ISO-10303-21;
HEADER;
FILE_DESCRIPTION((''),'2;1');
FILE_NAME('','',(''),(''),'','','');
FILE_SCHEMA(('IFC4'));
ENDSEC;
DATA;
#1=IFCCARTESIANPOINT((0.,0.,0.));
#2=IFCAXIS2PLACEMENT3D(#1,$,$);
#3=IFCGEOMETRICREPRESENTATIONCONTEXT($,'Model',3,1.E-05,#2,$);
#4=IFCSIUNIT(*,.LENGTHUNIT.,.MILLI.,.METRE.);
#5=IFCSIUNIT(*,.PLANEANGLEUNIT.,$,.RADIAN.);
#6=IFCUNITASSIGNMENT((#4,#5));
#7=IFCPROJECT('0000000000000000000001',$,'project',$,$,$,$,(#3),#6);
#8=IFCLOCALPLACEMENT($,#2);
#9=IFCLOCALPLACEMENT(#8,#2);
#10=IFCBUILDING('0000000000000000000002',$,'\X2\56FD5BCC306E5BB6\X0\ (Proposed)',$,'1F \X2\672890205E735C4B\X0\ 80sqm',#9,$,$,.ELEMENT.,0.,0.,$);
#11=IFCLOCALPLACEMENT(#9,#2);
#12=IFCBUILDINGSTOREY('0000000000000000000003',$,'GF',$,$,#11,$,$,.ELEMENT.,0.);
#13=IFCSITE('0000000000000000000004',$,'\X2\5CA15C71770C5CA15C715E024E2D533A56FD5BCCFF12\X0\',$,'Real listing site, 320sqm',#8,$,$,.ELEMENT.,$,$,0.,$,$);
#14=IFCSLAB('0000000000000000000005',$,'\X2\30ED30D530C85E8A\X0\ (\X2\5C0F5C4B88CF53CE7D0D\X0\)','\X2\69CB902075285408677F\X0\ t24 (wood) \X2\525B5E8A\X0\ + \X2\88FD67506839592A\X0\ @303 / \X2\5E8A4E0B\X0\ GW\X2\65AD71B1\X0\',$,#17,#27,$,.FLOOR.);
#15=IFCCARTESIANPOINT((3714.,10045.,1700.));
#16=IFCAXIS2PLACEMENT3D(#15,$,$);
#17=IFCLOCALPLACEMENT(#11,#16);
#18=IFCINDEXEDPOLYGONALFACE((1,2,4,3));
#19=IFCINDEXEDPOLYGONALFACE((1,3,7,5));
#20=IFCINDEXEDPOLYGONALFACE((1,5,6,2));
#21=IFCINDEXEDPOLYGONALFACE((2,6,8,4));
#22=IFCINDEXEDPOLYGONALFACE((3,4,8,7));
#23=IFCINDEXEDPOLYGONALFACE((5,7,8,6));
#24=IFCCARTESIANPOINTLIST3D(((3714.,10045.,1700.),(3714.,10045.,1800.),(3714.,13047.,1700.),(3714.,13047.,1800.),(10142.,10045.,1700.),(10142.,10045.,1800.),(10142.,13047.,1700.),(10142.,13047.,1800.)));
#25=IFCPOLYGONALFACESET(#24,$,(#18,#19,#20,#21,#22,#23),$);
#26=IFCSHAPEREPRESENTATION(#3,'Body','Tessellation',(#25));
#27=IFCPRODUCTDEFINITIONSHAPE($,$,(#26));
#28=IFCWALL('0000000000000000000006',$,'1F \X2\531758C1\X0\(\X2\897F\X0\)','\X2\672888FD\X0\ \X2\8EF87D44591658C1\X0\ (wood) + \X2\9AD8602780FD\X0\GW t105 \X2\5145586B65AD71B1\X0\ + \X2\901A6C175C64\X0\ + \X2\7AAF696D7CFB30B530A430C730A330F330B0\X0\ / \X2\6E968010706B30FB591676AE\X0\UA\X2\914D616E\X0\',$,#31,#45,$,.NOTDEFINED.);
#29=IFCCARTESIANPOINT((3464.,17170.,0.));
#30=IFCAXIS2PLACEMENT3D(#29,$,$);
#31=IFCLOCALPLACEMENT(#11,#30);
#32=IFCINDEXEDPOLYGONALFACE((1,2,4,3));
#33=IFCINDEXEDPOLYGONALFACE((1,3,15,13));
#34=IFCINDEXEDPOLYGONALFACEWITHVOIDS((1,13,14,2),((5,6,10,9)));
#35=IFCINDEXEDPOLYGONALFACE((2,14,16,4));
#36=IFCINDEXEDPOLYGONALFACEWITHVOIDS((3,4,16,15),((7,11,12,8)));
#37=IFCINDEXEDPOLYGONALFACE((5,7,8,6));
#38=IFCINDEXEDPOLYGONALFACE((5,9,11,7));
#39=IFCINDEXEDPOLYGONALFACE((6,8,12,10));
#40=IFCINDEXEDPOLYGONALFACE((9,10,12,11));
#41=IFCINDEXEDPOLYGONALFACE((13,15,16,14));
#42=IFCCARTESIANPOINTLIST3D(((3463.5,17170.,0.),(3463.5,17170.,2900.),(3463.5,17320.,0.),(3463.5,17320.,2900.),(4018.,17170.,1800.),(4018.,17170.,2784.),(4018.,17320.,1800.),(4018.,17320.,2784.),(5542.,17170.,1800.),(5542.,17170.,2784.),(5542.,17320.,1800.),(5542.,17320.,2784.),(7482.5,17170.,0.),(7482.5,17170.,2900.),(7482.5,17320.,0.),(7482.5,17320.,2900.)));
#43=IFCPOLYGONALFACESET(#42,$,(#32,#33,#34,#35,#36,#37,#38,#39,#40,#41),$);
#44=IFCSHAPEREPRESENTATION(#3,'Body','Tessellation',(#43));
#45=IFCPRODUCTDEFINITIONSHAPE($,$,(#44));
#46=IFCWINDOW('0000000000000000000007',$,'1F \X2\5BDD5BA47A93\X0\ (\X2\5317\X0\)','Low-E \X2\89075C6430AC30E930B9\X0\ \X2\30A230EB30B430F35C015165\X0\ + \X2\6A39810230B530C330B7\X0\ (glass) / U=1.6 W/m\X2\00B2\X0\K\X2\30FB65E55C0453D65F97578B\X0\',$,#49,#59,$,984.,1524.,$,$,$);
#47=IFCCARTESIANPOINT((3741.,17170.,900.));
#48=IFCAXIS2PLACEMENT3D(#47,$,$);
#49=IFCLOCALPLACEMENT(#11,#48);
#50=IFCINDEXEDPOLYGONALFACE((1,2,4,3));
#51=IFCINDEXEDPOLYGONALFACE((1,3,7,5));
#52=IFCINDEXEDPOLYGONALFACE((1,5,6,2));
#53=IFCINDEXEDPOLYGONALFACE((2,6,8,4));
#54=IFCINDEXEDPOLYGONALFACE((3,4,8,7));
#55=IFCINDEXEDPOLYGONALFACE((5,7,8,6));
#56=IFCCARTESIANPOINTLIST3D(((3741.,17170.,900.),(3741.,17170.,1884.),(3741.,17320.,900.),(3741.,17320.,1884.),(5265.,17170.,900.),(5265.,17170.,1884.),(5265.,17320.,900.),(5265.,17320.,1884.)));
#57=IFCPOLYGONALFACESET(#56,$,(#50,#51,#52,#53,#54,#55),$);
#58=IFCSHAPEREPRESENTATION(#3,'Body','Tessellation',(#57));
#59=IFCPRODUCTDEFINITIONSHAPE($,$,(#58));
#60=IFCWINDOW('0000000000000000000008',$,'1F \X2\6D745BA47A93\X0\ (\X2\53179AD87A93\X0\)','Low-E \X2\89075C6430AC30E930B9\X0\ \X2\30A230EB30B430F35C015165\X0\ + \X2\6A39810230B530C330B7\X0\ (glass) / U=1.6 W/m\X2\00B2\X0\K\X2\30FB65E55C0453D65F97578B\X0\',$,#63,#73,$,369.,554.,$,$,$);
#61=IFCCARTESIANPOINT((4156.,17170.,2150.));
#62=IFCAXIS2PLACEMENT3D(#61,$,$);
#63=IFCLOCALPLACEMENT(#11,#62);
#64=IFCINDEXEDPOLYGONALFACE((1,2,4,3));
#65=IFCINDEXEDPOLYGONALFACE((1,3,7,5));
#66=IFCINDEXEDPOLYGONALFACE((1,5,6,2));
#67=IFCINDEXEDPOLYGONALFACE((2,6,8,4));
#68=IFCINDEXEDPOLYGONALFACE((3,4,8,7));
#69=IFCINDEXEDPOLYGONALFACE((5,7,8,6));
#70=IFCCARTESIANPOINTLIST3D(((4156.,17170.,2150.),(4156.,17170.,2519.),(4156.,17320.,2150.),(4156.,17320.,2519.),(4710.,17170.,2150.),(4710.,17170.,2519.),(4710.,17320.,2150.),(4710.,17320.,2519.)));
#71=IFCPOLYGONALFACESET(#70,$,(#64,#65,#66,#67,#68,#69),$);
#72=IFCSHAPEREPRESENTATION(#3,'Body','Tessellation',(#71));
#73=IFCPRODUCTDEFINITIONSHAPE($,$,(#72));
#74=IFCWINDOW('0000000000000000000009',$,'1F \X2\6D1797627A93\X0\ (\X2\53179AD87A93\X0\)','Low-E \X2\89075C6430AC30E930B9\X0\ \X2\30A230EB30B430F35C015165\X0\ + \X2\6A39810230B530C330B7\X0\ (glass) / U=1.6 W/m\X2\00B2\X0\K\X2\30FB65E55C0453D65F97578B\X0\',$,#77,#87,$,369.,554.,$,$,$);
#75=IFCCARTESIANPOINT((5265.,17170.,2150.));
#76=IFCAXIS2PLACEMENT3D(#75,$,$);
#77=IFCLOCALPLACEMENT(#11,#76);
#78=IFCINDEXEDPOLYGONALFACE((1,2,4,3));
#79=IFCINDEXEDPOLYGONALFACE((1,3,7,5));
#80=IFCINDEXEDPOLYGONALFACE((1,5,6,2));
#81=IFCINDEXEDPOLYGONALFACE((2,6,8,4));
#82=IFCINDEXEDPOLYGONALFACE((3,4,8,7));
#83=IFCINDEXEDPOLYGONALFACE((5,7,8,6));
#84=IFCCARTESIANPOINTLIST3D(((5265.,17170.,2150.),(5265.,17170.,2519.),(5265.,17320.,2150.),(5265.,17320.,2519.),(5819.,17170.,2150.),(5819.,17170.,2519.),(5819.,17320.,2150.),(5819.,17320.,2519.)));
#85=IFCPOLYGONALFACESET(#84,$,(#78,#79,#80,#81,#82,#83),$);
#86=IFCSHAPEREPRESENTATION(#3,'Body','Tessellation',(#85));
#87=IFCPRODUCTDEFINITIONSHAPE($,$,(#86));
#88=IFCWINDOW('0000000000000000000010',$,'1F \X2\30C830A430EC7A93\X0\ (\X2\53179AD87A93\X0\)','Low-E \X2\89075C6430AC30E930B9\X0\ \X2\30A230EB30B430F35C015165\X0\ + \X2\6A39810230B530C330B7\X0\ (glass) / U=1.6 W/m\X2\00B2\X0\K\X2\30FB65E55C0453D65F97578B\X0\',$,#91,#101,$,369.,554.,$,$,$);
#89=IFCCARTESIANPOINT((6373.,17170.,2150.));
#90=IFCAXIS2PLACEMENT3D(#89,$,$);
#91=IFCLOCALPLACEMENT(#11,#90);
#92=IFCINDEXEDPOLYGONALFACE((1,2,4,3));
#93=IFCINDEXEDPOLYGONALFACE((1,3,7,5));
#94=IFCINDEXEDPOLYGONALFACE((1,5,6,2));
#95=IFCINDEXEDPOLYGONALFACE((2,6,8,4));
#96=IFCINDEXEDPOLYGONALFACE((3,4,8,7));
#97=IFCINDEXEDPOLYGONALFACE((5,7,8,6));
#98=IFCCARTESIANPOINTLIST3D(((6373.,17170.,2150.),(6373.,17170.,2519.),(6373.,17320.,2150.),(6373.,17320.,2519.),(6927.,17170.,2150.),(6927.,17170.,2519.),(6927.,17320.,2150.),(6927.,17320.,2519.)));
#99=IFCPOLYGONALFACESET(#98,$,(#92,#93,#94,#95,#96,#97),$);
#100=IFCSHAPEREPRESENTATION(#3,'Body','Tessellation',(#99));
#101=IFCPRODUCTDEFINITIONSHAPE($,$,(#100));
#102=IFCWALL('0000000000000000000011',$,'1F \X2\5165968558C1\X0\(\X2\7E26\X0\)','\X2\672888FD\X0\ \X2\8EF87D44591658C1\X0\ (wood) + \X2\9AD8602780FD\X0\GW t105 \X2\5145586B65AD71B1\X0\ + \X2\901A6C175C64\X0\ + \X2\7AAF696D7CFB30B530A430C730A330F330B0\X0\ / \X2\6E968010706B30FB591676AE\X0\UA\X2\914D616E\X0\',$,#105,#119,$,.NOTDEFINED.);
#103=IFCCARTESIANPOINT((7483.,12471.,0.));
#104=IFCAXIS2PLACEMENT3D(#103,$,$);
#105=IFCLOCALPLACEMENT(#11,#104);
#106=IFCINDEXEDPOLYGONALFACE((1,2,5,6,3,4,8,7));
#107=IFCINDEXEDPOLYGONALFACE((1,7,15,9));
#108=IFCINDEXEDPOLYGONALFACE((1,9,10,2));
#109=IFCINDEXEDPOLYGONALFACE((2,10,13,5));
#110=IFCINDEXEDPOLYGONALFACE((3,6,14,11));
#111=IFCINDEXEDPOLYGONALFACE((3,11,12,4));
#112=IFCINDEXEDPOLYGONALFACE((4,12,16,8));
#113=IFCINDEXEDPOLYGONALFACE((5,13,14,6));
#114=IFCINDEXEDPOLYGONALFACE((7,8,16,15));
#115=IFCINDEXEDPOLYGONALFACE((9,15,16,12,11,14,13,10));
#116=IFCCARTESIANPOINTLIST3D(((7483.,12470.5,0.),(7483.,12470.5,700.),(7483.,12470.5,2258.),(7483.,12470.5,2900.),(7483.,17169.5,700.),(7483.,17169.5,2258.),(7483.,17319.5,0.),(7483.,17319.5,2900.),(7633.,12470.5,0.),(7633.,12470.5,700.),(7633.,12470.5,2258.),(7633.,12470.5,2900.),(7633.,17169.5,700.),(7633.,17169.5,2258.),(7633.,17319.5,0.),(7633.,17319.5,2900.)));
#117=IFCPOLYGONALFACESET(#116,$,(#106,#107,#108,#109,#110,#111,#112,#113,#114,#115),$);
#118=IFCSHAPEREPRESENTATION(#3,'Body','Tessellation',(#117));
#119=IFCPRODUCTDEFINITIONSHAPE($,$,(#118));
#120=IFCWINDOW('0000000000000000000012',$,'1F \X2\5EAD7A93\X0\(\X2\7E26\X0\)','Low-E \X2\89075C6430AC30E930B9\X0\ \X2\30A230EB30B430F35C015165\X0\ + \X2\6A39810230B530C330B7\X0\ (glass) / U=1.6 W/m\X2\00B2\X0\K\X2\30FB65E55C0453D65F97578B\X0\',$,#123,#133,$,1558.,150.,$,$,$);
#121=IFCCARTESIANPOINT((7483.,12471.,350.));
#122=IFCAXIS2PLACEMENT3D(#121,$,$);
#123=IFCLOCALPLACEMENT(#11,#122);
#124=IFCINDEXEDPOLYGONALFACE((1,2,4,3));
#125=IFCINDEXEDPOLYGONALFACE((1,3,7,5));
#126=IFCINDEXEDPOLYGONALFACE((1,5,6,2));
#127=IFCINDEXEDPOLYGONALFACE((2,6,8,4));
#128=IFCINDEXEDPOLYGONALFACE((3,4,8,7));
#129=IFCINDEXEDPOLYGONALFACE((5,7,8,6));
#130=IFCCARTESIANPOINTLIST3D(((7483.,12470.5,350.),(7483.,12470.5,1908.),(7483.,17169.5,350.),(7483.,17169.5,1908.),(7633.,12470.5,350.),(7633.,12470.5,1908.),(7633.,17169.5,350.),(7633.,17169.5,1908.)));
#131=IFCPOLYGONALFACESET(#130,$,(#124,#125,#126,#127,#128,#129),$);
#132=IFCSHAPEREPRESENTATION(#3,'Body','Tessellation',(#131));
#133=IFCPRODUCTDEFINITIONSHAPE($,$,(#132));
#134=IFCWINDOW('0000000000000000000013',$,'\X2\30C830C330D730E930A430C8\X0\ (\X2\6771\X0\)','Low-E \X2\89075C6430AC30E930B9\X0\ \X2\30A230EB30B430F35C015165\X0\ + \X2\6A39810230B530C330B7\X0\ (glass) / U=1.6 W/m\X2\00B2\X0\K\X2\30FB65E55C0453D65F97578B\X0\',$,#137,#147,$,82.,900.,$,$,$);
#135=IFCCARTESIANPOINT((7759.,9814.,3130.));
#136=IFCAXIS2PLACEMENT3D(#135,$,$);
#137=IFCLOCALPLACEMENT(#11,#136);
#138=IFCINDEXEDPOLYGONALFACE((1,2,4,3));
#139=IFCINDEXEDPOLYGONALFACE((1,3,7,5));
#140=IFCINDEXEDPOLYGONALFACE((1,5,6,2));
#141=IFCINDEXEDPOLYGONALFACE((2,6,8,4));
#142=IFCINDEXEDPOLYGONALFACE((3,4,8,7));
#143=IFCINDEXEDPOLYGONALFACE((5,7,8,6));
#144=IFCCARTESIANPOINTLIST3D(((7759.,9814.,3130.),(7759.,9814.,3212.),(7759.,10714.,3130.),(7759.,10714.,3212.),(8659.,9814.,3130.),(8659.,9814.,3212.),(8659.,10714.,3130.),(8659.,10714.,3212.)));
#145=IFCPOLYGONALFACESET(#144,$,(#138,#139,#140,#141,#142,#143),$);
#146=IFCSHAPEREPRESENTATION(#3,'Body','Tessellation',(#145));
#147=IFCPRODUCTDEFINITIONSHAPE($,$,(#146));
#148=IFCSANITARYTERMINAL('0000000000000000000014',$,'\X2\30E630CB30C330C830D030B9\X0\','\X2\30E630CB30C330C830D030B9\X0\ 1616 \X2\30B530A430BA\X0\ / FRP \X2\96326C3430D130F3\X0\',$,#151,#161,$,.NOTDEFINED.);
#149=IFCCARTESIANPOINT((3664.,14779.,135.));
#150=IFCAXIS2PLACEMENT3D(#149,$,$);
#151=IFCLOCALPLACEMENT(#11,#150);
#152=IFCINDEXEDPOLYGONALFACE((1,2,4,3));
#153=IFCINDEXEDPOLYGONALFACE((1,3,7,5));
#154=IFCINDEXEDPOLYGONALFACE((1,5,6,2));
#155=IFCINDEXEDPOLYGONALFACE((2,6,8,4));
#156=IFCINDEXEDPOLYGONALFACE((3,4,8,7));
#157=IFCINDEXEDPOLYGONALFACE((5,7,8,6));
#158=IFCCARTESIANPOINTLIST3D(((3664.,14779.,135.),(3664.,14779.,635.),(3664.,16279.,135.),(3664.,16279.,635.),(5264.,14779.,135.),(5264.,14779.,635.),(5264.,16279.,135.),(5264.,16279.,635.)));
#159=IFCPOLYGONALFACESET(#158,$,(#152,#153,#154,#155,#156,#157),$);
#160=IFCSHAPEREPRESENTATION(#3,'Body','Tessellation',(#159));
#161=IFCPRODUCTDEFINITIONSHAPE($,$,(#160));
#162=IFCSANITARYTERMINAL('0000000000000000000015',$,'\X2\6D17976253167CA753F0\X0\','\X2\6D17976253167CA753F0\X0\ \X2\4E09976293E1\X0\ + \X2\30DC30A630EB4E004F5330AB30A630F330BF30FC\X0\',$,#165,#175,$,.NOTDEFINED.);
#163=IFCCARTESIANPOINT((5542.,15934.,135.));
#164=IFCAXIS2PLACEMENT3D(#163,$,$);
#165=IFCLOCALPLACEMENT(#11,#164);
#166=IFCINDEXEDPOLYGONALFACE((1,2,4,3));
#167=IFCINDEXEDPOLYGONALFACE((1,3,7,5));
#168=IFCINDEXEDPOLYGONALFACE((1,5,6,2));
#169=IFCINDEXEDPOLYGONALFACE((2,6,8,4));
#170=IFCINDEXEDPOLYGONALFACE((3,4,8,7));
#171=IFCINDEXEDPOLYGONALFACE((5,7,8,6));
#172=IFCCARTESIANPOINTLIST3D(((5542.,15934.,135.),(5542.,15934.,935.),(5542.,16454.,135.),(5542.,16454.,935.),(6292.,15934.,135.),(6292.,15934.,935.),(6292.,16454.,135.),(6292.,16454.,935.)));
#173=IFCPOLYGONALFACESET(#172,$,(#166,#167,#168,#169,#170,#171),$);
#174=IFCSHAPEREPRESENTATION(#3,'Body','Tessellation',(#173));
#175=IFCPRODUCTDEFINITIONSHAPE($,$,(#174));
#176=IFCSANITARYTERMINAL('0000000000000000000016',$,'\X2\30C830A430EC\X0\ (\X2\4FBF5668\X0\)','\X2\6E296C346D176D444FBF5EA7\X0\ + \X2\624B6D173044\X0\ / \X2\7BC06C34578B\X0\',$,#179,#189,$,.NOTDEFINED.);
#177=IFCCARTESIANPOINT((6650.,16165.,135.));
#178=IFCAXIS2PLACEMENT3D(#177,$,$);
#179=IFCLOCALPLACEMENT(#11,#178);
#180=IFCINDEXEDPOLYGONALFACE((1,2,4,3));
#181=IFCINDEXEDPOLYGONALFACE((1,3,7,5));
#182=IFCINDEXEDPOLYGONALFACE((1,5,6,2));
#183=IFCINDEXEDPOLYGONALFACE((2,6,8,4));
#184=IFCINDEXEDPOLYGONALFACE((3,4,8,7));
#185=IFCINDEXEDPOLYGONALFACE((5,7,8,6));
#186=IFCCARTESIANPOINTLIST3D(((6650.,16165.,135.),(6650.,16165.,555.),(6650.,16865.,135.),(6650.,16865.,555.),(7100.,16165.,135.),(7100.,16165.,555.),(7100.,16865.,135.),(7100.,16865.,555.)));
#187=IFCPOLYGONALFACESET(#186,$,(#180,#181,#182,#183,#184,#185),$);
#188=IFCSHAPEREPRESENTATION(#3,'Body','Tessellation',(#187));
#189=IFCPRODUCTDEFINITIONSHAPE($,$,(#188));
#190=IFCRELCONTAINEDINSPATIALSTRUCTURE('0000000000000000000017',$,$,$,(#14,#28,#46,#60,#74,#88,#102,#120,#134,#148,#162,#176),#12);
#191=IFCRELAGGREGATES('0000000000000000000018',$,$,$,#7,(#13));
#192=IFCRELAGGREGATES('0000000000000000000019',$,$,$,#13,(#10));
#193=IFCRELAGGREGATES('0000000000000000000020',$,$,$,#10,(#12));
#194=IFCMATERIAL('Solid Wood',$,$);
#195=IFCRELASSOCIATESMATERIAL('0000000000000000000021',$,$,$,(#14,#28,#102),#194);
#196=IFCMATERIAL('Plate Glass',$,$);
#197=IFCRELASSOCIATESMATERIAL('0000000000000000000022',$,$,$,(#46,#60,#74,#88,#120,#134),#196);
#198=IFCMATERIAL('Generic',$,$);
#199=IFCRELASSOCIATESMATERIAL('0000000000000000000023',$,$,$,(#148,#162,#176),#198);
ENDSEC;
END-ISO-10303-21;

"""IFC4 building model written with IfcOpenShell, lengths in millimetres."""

from ifc_helpers import new_model, si_unit, frame, frame_2d, origin, place, context, project, spatial, rectangle, extrude, material, element, fill, save


model = new_model("IFC4")

# Units and contexts
model_context = context("Model", 3, precision=1e-05, world=origin())
ifc_project = project(units=[si_unit("LENGTHUNIT", "METRE", prefix="MILLI"), si_unit("PLANEANGLEUNIT", "RADIAN")], contexts=[model_context])

# Site, building, storey
site_placement = place(None, origin())
site = spatial("IfcSite", under=ifc_project, at=site_placement, Name="岡山県岡山市中区国富２", ObjectType="Real listing site, 320sqm", CompositionType="ELEMENT", RefElevation=0.0)
building_placement = place(site_placement, origin())
building = spatial("IfcBuilding", under=site, at=building_placement, Name="国富の家 (Proposed)", ObjectType="1F 木造平屋 80sqm", CompositionType="ELEMENT", ElevationOfRefHeight=0.0, ElevationOfTerrain=0.0)
storey_placement = place(building_placement, origin())
storey = spatial("IfcBuildingStorey", under=building, at=storey_placement, Name="GF", CompositionType="ELEMENT", Elevation=0.0)

# Slab
ifc_material_1 = material(Name="Solid Wood")
slab_1_placement = place(storey_placement, frame((3714.0, 10045.0, 1700.0)))
element("IfcSlab", 1, at=slab_1_placement, inside=storey, material=ifc_material_1, Name="ロフト床 (小屋裏収納)", Description="構造用合板 t24 (wood) 剛床 + 製材根太 @303 / 床下 GW断熱", PredefinedType="FLOOR", context=model_context, shape_type="SweptSolid", body=[
    extrude(rectangle(XDim=6428.0, YDim=3002.0, at=frame_2d((3214.0, 1501.0))), frame((3714.0, 10045.0, 1700.0)), (0.0, 0.0, 1.0), 100.0),
])

# Wall, openings, windows
wall_1_placement = place(storey_placement, frame((3464.0, 17170.0, 0.0)))
wall_1 = element("IfcWall", 2, at=wall_1_placement, inside=storey, material=ifc_material_1, Name="1F 北壁(西)", Description="木製 軸組外壁 (wood) + 高性能GW t105 充填断熱 + 通気層 + 窯業系サイディング / 準耐火・外皮UA配慮", PredefinedType="NOTDEFINED", context=model_context, shape_type="SweptSolid", body=[
    extrude(rectangle(XDim=4019.0, YDim=150.0, at=frame_2d((2009.0, 75.0))), frame((3464.0, 17170.0, 0.0)), (0.0, 0.0, 1.0), 2900.0),
])
opening_1_placement = place(storey_placement, frame((3741.0, 17170.0, 900.0)))
opening_1 = element("IfcOpeningElement", 3, at=opening_1_placement, cuts=wall_1, PredefinedType="NOTDEFINED", context=model_context, shape_type="SweptSolid", body=[
    extrude(rectangle(XDim=1524.0, YDim=150.0, at=frame_2d((762.0, 75.0))), frame((3741.0, 17170.0, 900.0)), (0.0, 0.0, 1.0), 984.0),
])
opening_2_placement = place(storey_placement, frame((4156.0, 17170.0, 2150.0)))
opening_2 = element("IfcOpeningElement", 4, at=opening_2_placement, cuts=wall_1, PredefinedType="NOTDEFINED", context=model_context, shape_type="SweptSolid", body=[
    extrude(rectangle(XDim=554.0, YDim=150.0, at=frame_2d((277.0, 75.0))), frame((4156.0, 17170.0, 2150.0)), (0.0, 0.0, 1.0), 369.0),
])
opening_3_placement = place(storey_placement, frame((5265.0, 17170.0, 2150.0)))
opening_3 = element("IfcOpeningElement", 5, at=opening_3_placement, cuts=wall_1, PredefinedType="NOTDEFINED", context=model_context, shape_type="SweptSolid", body=[
    extrude(rectangle(XDim=554.0, YDim=150.0, at=frame_2d((277.0, 75.0))), frame((5265.0, 17170.0, 2150.0)), (0.0, 0.0, 1.0), 369.0),
])
opening_4_placement = place(storey_placement, frame((6373.0, 17170.0, 2150.0)))
opening_4 = element("IfcOpeningElement", 6, at=opening_4_placement, cuts=wall_1, PredefinedType="NOTDEFINED", context=model_context, shape_type="SweptSolid", body=[
    extrude(rectangle(XDim=554.0, YDim=150.0, at=frame_2d((277.0, 75.0))), frame((6373.0, 17170.0, 2150.0)), (0.0, 0.0, 1.0), 369.0),
])
ifc_material_2 = material(Name="Plate Glass")
window_1_placement = place(storey_placement, frame((3741.0, 17170.0, 900.0)))
window_1 = element("IfcWindow", 7, at=window_1_placement, inside=storey, material=ifc_material_2, Name="1F 寝室窓 (北)", Description="Low-E 複層ガラス アルゴン封入 + 樹脂サッシ (glass) / U=1.6 W/m²K・日射取得型", OverallHeight=984.0, OverallWidth=1524.0, context=model_context, shape_type="SweptSolid", body=[
    extrude(rectangle(XDim=1524.0, YDim=150.0, at=frame_2d((762.0, 75.0))), frame((3741.0, 17170.0, 900.0)), (0.0, 0.0, 1.0), 984.0),
])
fill(opening_1, window_1)
window_2_placement = place(storey_placement, frame((4156.0, 17170.0, 2150.0)))
window_2 = element("IfcWindow", 8, at=window_2_placement, inside=storey, material=ifc_material_2, Name="1F 浴室窓 (北高窓)", Description="Low-E 複層ガラス アルゴン封入 + 樹脂サッシ (glass) / U=1.6 W/m²K・日射取得型", OverallHeight=369.0, OverallWidth=554.0, context=model_context, shape_type="SweptSolid", body=[
    extrude(rectangle(XDim=554.0, YDim=150.0, at=frame_2d((277.0, 75.0))), frame((4156.0, 17170.0, 2150.0)), (0.0, 0.0, 1.0), 369.0),
])
fill(opening_2, window_2)
window_3_placement = place(storey_placement, frame((5265.0, 17170.0, 2150.0)))
window_3 = element("IfcWindow", 9, at=window_3_placement, inside=storey, material=ifc_material_2, Name="1F 洗面窓 (北高窓)", Description="Low-E 複層ガラス アルゴン封入 + 樹脂サッシ (glass) / U=1.6 W/m²K・日射取得型", OverallHeight=369.0, OverallWidth=554.0, context=model_context, shape_type="SweptSolid", body=[
    extrude(rectangle(XDim=554.0, YDim=150.0, at=frame_2d((277.0, 75.0))), frame((5265.0, 17170.0, 2150.0)), (0.0, 0.0, 1.0), 369.0),
])
fill(opening_3, window_3)
window_4_placement = place(storey_placement, frame((6373.0, 17170.0, 2150.0)))
window_4 = element("IfcWindow", 10, at=window_4_placement, inside=storey, material=ifc_material_2, Name="1F トイレ窓 (北高窓)", Description="Low-E 複層ガラス アルゴン封入 + 樹脂サッシ (glass) / U=1.6 W/m²K・日射取得型", OverallHeight=369.0, OverallWidth=554.0, context=model_context, shape_type="SweptSolid", body=[
    extrude(rectangle(XDim=554.0, YDim=150.0, at=frame_2d((277.0, 75.0))), frame((6373.0, 17170.0, 2150.0)), (0.0, 0.0, 1.0), 369.0),
])
fill(opening_4, window_4)

# Wall, opening, window
wall_2_placement = place(storey_placement, frame((7483.0, 12471.0, 0.0)))
wall_2 = element("IfcWall", 11, at=wall_2_placement, inside=storey, material=ifc_material_1, Name="1F 入隅壁(縦)", Description="木製 軸組外壁 (wood) + 高性能GW t105 充填断熱 + 通気層 + 窯業系サイディング / 準耐火・外皮UA配慮", PredefinedType="NOTDEFINED", context=model_context, shape_type="SweptSolid", body=[
    extrude(rectangle(XDim=150.0, YDim=4849.0, at=frame_2d((75.0, 2424.0))), frame((7483.0, 12471.0, 0.0)), (0.0, 0.0, 1.0), 2900.0),
])
opening_5_placement = place(storey_placement, frame((7483.0, 12471.0, 350.0)))
opening_5 = element("IfcOpeningElement", 12, at=opening_5_placement, cuts=wall_2, PredefinedType="NOTDEFINED", context=model_context, shape_type="SweptSolid", body=[
    extrude(rectangle(XDim=150.0, YDim=4699.0, at=frame_2d((75.0, 2349.0))), frame((7483.0, 12471.0, 350.0)), (0.0, 0.0, 1.0), 1558.0),
])
window_5_placement = place(storey_placement, frame((7483.0, 12471.0, 350.0)))
window_5 = element("IfcWindow", 13, at=window_5_placement, inside=storey, material=ifc_material_2, Name="1F 庭窓(縦)", Description="Low-E 複層ガラス アルゴン封入 + 樹脂サッシ (glass) / U=1.6 W/m²K・日射取得型", OverallHeight=1558.0, OverallWidth=150.0, context=model_context, shape_type="SweptSolid", body=[
    extrude(rectangle(XDim=150.0, YDim=4699.0, at=frame_2d((75.0, 2349.0))), frame((7483.0, 12471.0, 350.0)), (0.0, 0.0, 1.0), 1558.0),
])
fill(opening_5, window_5)

# Window
window_6_placement = place(storey_placement, frame((7759.0, 9814.0, 3130.0)))
element("IfcWindow", 14, at=window_6_placement, inside=storey, material=ifc_material_2, Name="トップライト (東)", Description="Low-E 複層ガラス アルゴン封入 + 樹脂サッシ (glass) / U=1.6 W/m²K・日射取得型", OverallHeight=82.0, OverallWidth=900.0, context=model_context, shape_type="SweptSolid", body=[
    extrude(rectangle(XDim=900.0, YDim=900.0, at=frame_2d((450.0, 450.0))), frame((7759.0, 9814.0, 3130.0)), (0.0, 0.0, 1.0), 82.0),
])

# Shared definitions
ifc_material_3 = material(Name="Generic")

# Sanitary terminals
sanitary_terminal_1_placement = place(storey_placement, frame((3664.0, 14779.0, 135.0)))
element("IfcSanitaryTerminal", 15, at=sanitary_terminal_1_placement, inside=storey, material=ifc_material_3, Name="ユニットバス", Description="ユニットバス 1616 サイズ / FRP 防水パン", PredefinedType="NOTDEFINED", context=model_context, shape_type="SweptSolid", body=[
    extrude(rectangle(XDim=1600.0, YDim=1500.0, at=frame_2d((800.0, 750.0))), frame((3664.0, 14779.0, 135.0)), (0.0, 0.0, 1.0), 500.0),
])
sanitary_terminal_2_placement = place(storey_placement, frame((5542.0, 15934.0, 135.0)))
element("IfcSanitaryTerminal", 16, at=sanitary_terminal_2_placement, inside=storey, material=ifc_material_3, Name="洗面化粧台", Description="洗面化粧台 三面鏡 + ボウル一体カウンター", PredefinedType="NOTDEFINED", context=model_context, shape_type="SweptSolid", body=[
    extrude(rectangle(XDim=750.0, YDim=520.0, at=frame_2d((375.0, 260.0))), frame((5542.0, 15934.0, 135.0)), (0.0, 0.0, 1.0), 800.0),
])
sanitary_terminal_3_placement = place(storey_placement, frame((6650.0, 16165.0, 135.0)))
element("IfcSanitaryTerminal", 17, at=sanitary_terminal_3_placement, inside=storey, material=ifc_material_3, Name="トイレ (便器)", Description="温水洗浄便座 + 手洗い / 節水型", PredefinedType="NOTDEFINED", context=model_context, shape_type="SweptSolid", body=[
    extrude(rectangle(XDim=450.0, YDim=700.0, at=frame_2d((225.0, 350.0))), frame((6650.0, 16165.0, 135.0)), (0.0, 0.0, 1.0), 420.0),
])

save(model, "model.ifc")
